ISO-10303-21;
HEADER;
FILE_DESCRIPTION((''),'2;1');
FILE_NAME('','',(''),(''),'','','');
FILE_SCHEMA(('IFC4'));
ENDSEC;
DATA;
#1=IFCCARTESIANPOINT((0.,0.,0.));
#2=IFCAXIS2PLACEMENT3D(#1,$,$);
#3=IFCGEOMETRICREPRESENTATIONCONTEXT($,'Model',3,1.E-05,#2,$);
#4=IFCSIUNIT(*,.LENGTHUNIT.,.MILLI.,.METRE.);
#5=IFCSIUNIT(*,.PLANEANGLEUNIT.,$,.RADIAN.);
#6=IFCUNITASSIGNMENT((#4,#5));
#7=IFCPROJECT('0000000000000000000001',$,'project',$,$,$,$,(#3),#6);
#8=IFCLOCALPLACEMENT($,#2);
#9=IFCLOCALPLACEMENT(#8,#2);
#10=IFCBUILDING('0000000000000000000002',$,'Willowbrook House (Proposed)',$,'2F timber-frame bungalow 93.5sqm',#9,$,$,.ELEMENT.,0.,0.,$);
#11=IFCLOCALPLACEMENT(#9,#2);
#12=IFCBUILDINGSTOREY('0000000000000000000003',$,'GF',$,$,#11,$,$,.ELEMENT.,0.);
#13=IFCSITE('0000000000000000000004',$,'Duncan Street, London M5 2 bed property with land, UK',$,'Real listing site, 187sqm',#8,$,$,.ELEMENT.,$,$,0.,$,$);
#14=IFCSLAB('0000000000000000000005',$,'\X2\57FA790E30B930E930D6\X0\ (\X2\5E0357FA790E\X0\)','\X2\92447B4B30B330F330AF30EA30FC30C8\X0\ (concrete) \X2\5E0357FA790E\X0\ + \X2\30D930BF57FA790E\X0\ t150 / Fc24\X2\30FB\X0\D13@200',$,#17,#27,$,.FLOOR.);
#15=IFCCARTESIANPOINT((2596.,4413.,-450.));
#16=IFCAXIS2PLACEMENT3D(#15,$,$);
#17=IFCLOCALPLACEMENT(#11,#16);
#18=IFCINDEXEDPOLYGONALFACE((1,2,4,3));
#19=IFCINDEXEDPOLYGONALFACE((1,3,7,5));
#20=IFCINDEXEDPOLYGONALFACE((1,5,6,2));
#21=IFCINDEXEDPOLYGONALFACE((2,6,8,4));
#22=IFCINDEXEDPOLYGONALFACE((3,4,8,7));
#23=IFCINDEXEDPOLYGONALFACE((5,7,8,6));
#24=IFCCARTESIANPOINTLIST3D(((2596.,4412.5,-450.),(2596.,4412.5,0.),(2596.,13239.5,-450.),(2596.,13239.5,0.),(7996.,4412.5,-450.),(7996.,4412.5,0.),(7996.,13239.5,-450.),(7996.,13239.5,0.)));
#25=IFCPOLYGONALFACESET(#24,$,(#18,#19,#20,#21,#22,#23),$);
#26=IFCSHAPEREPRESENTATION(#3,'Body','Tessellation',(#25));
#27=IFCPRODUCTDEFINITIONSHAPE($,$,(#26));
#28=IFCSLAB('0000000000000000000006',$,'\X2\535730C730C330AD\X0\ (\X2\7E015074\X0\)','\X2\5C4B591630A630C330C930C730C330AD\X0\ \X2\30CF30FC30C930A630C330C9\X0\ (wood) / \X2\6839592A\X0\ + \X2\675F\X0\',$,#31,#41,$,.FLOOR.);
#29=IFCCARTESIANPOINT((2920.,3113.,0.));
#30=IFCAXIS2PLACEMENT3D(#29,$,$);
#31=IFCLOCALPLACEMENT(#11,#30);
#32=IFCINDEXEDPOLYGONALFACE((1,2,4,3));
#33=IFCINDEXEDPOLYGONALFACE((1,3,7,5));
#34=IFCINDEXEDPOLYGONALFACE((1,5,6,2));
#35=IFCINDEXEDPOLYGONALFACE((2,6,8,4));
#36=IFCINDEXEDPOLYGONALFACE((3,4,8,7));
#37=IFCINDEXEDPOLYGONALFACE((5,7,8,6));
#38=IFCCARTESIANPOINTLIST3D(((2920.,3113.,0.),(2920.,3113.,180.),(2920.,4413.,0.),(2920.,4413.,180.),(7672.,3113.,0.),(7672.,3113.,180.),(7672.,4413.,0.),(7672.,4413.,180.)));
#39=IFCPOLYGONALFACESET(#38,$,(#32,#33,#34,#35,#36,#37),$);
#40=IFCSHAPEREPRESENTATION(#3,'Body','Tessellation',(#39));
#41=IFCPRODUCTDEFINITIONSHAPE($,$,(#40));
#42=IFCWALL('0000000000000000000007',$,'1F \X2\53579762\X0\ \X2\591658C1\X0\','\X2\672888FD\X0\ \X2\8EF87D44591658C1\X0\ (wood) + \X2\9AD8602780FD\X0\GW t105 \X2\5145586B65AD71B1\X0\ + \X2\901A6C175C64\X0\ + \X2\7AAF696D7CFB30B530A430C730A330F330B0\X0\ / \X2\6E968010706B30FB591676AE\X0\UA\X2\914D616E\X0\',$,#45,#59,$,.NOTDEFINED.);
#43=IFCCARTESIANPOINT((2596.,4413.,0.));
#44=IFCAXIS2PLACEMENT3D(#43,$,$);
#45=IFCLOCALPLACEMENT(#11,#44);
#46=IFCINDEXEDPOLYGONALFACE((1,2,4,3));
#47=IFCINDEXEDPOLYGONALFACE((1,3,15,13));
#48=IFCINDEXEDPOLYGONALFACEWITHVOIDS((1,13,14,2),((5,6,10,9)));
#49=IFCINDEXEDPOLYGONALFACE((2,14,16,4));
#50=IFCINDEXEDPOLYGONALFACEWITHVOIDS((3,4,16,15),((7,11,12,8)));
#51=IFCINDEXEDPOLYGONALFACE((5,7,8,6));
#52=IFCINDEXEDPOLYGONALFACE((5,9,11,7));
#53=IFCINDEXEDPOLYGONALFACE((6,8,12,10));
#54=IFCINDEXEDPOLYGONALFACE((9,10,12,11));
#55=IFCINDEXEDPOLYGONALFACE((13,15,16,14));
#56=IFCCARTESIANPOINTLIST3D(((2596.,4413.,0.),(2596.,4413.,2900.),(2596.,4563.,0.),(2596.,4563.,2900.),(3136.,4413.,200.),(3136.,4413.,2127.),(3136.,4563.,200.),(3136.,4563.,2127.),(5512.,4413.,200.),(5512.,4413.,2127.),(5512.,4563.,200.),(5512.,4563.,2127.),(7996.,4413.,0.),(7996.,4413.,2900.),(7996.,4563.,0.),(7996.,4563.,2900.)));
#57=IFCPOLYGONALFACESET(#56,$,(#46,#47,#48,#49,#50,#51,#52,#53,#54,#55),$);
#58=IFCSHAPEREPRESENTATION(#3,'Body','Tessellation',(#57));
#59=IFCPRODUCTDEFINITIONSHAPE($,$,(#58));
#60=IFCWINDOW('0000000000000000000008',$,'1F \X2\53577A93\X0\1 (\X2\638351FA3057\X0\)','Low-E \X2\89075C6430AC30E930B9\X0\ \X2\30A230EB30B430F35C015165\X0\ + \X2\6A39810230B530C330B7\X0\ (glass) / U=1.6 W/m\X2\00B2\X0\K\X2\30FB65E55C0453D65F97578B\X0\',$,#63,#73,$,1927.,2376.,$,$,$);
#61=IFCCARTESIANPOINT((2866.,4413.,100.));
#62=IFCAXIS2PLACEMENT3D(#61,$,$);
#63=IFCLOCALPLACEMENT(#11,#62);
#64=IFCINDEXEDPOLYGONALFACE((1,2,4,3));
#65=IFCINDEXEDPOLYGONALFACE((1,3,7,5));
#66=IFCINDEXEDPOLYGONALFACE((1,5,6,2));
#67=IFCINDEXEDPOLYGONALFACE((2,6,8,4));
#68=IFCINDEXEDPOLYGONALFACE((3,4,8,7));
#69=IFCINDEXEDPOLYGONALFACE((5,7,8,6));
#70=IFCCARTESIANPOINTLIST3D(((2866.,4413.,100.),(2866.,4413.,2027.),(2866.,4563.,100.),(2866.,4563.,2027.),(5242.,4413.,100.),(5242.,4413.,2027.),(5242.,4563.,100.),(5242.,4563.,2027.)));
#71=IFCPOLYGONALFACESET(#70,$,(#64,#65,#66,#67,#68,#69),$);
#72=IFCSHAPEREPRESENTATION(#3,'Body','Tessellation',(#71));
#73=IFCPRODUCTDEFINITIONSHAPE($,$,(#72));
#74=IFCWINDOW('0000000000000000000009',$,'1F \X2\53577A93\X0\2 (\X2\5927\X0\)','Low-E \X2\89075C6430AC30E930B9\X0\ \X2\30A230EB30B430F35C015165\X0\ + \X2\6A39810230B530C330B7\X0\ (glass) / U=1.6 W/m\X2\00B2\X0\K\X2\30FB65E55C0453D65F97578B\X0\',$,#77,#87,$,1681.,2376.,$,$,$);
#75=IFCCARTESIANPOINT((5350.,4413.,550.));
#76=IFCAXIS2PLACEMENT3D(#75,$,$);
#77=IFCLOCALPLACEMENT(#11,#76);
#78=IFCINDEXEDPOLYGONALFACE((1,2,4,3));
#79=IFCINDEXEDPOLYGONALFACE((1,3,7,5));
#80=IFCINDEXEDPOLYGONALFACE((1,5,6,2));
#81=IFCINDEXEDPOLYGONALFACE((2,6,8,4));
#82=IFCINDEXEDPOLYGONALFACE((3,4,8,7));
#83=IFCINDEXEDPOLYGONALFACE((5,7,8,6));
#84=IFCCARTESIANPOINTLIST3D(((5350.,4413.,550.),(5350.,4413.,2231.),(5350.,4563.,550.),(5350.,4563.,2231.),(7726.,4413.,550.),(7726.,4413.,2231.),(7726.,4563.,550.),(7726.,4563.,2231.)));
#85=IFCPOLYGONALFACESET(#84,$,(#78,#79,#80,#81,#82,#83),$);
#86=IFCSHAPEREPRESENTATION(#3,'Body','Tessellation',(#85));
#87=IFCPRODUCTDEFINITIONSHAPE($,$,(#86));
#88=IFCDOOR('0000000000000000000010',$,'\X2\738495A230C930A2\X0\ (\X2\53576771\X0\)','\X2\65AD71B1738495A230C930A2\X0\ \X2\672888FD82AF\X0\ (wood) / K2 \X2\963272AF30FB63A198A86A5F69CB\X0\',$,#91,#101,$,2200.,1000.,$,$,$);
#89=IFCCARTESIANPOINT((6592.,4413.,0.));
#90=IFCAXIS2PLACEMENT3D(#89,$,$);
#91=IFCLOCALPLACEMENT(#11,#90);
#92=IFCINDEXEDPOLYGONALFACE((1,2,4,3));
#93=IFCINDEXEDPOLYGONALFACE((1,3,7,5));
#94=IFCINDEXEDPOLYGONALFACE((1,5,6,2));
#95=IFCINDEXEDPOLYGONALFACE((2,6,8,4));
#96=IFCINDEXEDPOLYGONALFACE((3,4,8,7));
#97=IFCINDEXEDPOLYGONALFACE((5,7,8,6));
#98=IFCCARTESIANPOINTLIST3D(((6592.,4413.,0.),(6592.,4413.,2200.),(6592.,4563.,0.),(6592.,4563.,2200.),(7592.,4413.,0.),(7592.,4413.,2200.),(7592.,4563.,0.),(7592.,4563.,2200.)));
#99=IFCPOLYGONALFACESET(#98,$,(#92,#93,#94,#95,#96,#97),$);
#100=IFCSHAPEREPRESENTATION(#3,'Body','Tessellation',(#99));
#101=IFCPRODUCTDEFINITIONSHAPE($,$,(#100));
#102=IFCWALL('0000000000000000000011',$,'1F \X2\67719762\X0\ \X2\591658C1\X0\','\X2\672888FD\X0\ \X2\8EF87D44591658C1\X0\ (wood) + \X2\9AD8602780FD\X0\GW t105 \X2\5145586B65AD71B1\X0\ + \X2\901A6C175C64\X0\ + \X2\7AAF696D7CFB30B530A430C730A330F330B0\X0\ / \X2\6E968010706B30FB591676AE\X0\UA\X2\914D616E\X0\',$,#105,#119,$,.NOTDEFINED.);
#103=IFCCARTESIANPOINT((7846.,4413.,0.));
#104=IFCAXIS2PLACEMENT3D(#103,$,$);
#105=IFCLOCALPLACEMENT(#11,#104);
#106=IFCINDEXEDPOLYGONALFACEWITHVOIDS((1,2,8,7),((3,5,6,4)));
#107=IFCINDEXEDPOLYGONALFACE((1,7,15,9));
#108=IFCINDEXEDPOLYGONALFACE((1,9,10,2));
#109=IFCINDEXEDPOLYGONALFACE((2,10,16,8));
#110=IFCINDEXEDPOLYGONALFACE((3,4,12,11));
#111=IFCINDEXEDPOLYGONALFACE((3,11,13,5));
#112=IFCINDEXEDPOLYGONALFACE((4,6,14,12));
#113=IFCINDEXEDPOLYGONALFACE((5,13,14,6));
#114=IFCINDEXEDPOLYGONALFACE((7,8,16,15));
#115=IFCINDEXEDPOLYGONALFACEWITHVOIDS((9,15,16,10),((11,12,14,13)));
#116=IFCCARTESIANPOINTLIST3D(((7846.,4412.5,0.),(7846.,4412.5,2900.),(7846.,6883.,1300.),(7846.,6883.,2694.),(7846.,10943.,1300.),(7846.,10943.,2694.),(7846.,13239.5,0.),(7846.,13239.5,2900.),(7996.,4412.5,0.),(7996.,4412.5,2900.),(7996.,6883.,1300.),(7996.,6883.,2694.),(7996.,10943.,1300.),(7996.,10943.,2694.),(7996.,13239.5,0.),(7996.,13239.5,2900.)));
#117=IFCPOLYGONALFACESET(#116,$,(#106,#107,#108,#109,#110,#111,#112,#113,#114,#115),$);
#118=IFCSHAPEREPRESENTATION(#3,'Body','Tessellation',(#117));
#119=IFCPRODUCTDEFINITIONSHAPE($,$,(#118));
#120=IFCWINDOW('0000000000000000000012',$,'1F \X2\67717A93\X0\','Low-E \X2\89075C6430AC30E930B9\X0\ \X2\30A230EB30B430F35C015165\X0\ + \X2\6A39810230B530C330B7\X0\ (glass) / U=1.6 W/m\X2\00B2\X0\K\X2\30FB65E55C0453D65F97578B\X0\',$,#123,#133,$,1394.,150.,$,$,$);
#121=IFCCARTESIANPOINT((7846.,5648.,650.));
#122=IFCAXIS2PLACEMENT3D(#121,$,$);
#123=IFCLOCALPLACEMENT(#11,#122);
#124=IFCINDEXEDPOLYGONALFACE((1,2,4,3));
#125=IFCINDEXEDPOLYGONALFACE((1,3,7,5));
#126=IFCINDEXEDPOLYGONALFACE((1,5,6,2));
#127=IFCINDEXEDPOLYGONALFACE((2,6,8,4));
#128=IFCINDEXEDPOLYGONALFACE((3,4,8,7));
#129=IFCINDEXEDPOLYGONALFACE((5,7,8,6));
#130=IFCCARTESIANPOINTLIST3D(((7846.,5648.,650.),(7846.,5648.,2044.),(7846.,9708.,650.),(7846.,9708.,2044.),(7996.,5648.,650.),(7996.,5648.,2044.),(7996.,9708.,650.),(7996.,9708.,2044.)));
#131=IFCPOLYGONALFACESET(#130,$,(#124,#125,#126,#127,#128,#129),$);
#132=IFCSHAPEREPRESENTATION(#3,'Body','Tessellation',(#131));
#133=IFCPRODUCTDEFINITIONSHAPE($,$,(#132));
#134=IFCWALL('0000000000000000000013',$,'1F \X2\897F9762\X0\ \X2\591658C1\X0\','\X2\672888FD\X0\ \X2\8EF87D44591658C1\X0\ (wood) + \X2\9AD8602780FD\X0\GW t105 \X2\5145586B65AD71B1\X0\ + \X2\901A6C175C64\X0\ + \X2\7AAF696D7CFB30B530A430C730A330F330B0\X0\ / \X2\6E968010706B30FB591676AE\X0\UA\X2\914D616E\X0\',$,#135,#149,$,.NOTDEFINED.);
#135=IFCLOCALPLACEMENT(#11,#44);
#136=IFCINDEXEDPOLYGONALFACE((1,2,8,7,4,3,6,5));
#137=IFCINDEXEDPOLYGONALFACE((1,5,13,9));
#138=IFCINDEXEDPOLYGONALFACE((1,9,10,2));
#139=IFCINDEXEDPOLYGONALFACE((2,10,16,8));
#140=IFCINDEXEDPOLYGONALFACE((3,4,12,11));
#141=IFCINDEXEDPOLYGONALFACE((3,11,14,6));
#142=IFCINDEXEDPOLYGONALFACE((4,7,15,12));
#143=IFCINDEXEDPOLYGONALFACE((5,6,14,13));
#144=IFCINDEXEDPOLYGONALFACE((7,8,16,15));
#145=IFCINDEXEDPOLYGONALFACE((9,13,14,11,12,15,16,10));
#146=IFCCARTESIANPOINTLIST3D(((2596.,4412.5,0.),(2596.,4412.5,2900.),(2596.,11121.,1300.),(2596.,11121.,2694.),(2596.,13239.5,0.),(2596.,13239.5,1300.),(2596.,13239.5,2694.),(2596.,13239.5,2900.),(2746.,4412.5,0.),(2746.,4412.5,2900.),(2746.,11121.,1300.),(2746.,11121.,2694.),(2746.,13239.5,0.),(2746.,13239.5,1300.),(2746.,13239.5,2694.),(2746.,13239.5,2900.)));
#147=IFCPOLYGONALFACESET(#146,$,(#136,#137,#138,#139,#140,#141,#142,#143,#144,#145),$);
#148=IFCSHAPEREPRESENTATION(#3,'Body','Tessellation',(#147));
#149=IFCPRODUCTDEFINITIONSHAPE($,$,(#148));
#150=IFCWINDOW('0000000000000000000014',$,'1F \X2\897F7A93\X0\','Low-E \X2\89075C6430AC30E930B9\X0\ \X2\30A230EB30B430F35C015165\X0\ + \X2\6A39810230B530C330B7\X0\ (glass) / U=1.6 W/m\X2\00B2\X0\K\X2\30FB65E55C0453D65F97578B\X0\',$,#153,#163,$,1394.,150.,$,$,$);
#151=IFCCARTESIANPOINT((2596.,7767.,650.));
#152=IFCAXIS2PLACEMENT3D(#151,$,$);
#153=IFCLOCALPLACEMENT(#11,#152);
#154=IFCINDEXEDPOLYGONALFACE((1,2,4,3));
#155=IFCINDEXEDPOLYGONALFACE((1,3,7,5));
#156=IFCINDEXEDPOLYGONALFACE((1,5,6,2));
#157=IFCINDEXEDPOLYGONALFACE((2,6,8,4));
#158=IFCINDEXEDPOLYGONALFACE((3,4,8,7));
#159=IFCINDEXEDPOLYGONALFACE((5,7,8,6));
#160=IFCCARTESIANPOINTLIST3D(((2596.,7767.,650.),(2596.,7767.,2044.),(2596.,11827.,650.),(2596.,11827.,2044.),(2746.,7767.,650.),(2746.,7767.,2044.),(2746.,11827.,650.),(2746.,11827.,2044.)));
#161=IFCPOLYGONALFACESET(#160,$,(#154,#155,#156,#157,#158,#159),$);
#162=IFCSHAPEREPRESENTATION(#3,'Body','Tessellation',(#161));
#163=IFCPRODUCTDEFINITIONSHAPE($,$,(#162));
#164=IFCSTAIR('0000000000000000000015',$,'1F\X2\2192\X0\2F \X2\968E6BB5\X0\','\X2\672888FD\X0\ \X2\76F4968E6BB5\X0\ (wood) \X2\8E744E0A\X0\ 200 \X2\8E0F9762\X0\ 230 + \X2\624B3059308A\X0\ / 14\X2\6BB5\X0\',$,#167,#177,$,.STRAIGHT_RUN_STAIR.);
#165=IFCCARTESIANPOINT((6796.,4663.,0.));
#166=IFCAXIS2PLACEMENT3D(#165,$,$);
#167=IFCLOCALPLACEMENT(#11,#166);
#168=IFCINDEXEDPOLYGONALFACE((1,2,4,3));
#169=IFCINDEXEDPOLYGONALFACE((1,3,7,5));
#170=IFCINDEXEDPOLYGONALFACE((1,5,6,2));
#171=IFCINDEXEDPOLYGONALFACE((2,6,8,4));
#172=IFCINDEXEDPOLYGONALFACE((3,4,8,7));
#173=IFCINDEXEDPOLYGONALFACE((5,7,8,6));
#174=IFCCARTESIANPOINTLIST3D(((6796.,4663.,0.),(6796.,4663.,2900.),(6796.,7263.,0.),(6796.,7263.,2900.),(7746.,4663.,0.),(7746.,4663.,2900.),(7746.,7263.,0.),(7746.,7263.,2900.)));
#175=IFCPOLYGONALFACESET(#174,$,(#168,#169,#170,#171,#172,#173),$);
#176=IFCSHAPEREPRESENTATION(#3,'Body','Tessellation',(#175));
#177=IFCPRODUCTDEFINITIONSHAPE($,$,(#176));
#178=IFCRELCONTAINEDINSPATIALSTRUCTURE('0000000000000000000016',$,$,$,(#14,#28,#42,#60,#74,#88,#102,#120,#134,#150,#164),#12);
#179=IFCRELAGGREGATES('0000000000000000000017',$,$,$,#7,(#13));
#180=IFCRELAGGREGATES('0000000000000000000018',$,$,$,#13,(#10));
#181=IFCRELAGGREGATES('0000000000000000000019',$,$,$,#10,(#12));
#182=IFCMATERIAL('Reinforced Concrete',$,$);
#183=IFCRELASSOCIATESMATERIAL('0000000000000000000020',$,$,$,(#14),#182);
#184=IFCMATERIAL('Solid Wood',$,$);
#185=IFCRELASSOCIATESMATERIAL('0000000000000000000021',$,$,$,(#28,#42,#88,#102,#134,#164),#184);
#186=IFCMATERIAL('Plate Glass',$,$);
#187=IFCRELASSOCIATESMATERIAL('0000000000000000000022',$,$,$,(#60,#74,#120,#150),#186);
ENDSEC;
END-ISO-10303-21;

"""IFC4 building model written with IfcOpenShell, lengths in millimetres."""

from ifc_helpers import new_model, si_unit, frame, frame_2d, origin, place, context, project, spatial, rectangle, extrude, material, element, fill, save


model = new_model("IFC4")

# Units and contexts
model_context = context("Model", 3, precision=1e-05, world=origin())
ifc_project = project(units=[si_unit("LENGTHUNIT", "METRE", prefix="MILLI"), si_unit("PLANEANGLEUNIT", "RADIAN")], contexts=[model_context])

# Site, building, storey
site_placement = place(None, origin())
site = spatial("IfcSite", under=ifc_project, at=site_placement, Name="Duncan Street, London M5 2 bed property with land, UK", ObjectType="Real listing site, 187sqm", CompositionType="ELEMENT", RefElevation=0.0)
building_placement = place(site_placement, origin())
building = spatial("IfcBuilding", under=site, at=building_placement, Name="Willowbrook House (Proposed)", ObjectType="2F timber-frame bungalow 93.5sqm", CompositionType="ELEMENT", ElevationOfRefHeight=0.0, ElevationOfTerrain=0.0)
storey_placement = place(building_placement, origin())
storey = spatial("IfcBuildingStorey", under=building, at=storey_placement, Name="GF", CompositionType="ELEMENT", Elevation=0.0)

# Slabs
ifc_material_1 = material(Name="Reinforced Concrete")
slab_1_placement = place(storey_placement, frame((2596.0, 4413.0, -450.0)))
element("IfcSlab", 1, at=slab_1_placement, inside=storey, material=ifc_material_1, Name="基礎スラブ (布基礎)", Description="鉄筋コンクリート (concrete) 布基礎 + ベタ基礎 t150 / Fc24・D13@200", PredefinedType="FLOOR", context=model_context, shape_type="SweptSolid", body=[
    extrude(rectangle(XDim=5400.0, YDim=8827.0, at=frame_2d((2700.0, 4413.0))), frame((2596.0, 4413.0, -450.0)), (0.0, 0.0, 1.0), 450.0),
])
ifc_material_2 = material(Name="Solid Wood")
slab_2_placement = place(storey_placement, frame((2920.0, 3113.0, 0.0)))
element("IfcSlab", 2, at=slab_2_placement, inside=storey, material=ifc_material_2, Name="南デッキ (縁側)", Description="屋外ウッドデッキ ハードウッド (wood) / 根太 + 束", PredefinedType="FLOOR", context=model_context, shape_type="SweptSolid", body=[
    extrude(rectangle(XDim=4752.0, YDim=1300.0, at=frame_2d((2376.0, 650.0))), frame((2920.0, 3113.0, 0.0)), (0.0, 0.0, 1.0), 180.0),
])

# Wall, openings, windows, door
wall_1_placement = place(storey_placement, frame((2596.0, 4413.0, 0.0)))
wall_1 = element("IfcWall", 3, at=wall_1_placement, inside=storey, material=ifc_material_2, Name="1F 南面 外壁", Description="木製 軸組外壁 (wood) + 高性能GW t105 充填断熱 + 通気層 + 窯業系サイディング / 準耐火・外皮UA配慮", PredefinedType="NOTDEFINED", context=model_context, shape_type="SweptSolid", body=[
    extrude(rectangle(XDim=5400.0, YDim=150.0, at=frame_2d((2700.0, 75.0))), frame((2596.0, 4413.0, 0.0)), (0.0, 0.0, 1.0), 2900.0),
])
opening_1_placement = place(storey_placement, frame((2866.0, 4413.0, 100.0)))
opening_1 = element("IfcOpeningElement", 4, at=opening_1_placement, cuts=wall_1, PredefinedType="NOTDEFINED", context=model_context, shape_type="SweptSolid", body=[
    extrude(rectangle(XDim=2376.0, YDim=150.0, at=frame_2d((1188.0, 75.0))), frame((2866.0, 4413.0, 100.0)), (0.0, 0.0, 1.0), 1927.0),
])
opening_2_placement = place(storey_placement, frame((5350.0, 4413.0, 550.0)))
opening_2 = element("IfcOpeningElement", 5, at=opening_2_placement, cuts=wall_1, PredefinedType="NOTDEFINED", context=model_context, shape_type="SweptSolid", body=[
    extrude(rectangle(XDim=2376.0, YDim=150.0, at=frame_2d((1188.0, 75.0))), frame((5350.0, 4413.0, 550.0)), (0.0, 0.0, 1.0), 1681.0),
])
opening_3_placement = place(storey_placement, frame((6592.0, 4413.0, 0.0)))
opening_3 = element("IfcOpeningElement", 6, at=opening_3_placement, cuts=wall_1, PredefinedType="NOTDEFINED", context=model_context, shape_type="SweptSolid", body=[
    extrude(rectangle(XDim=1000.0, YDim=150.0, at=frame_2d((500.0, 75.0))), frame((6592.0, 4413.0, 0.0)), (0.0, 0.0, 1.0), 2200.0),
])
ifc_material_3 = material(Name="Plate Glass")
window_1_placement = place(storey_placement, frame((2866.0, 4413.0, 100.0)))
window_1 = element("IfcWindow", 7, at=window_1_placement, inside=storey, material=ifc_material_3, Name="1F 南窓1 (掃出し)", Description="Low-E 複層ガラス アルゴン封入 + 樹脂サッシ (glass) / U=1.6 W/m²K・日射取得型", OverallHeight=1927.0, OverallWidth=2376.0, context=model_context, shape_type="SweptSolid", body=[
    extrude(rectangle(XDim=2376.0, YDim=150.0, at=frame_2d((1188.0, 75.0))), frame((2866.0, 4413.0, 100.0)), (0.0, 0.0, 1.0), 1927.0),
])
fill(opening_1, window_1)
window_2_placement = place(storey_placement, frame((5350.0, 4413.0, 550.0)))
window_2 = element("IfcWindow", 8, at=window_2_placement, inside=storey, material=ifc_material_3, Name="1F 南窓2 (大)", Description="Low-E 複層ガラス アルゴン封入 + 樹脂サッシ (glass) / U=1.6 W/m²K・日射取得型", OverallHeight=1681.0, OverallWidth=2376.0, context=model_context, shape_type="SweptSolid", body=[
    extrude(rectangle(XDim=2376.0, YDim=150.0, at=frame_2d((1188.0, 75.0))), frame((5350.0, 4413.0, 550.0)), (0.0, 0.0, 1.0), 1681.0),
])
fill(opening_2, window_2)
door_placement = place(storey_placement, frame((6592.0, 4413.0, 0.0)))
door = element("IfcDoor", 9, at=door_placement, inside=storey, material=ifc_material_2, Name="玄関ドア (南東)", Description="断熱玄関ドア 木製芯 (wood) / K2 防犯・採風機構", OverallHeight=2200.0, OverallWidth=1000.0, context=model_context, shape_type="SweptSolid", body=[
    extrude(rectangle(XDim=1000.0, YDim=150.0, at=frame_2d((500.0, 75.0))), frame((6592.0, 4413.0, 0.0)), (0.0, 0.0, 1.0), 2200.0),
])
fill(opening_3, door)

# Walls, openings, windows
wall_2_placement = place(storey_placement, frame((7846.0, 4413.0, 0.0)))
wall_2 = element("IfcWall", 10, at=wall_2_placement, inside=storey, material=ifc_material_2, Name="1F 東面 外壁", Description="木製 軸組外壁 (wood) + 高性能GW t105 充填断熱 + 通気層 + 窯業系サイディング / 準耐火・外皮UA配慮", PredefinedType="NOTDEFINED", context=model_context, shape_type="SweptSolid", body=[
    extrude(rectangle(XDim=150.0, YDim=8827.0, at=frame_2d((75.0, 4413.0))), frame((7846.0, 4413.0, 0.0)), (0.0, 0.0, 1.0), 2900.0),
])
opening_4_placement = place(storey_placement, frame((7846.0, 5648.0, 650.0)))
opening_4 = element("IfcOpeningElement", 11, at=opening_4_placement, cuts=wall_2, PredefinedType="NOTDEFINED", context=model_context, shape_type="SweptSolid", body=[
    extrude(rectangle(XDim=150.0, YDim=4060.0, at=frame_2d((75.0, 2030.0))), frame((7846.0, 5648.0, 650.0)), (0.0, 0.0, 1.0), 1394.0),
])
window_3_placement = place(storey_placement, frame((7846.0, 5648.0, 650.0)))
window_3 = element("IfcWindow", 12, at=window_3_placement, inside=storey, material=ifc_material_3, Name="1F 東窓", Description="Low-E 複層ガラス アルゴン封入 + 樹脂サッシ (glass) / U=1.6 W/m²K・日射取得型", OverallHeight=1394.0, OverallWidth=150.0, context=model_context, shape_type="SweptSolid", body=[
    extrude(rectangle(XDim=150.0, YDim=4060.0, at=frame_2d((75.0, 2030.0))), frame((7846.0, 5648.0, 650.0)), (0.0, 0.0, 1.0), 1394.0),
])
fill(opening_4, window_3)
wall_3_placement = place(storey_placement, frame((2596.0, 4413.0, 0.0)))
wall_3 = element("IfcWall", 13, at=wall_3_placement, inside=storey, material=ifc_material_2, Name="1F 西面 外壁", Description="木製 軸組外壁 (wood) + 高性能GW t105 充填断熱 + 通気層 + 窯業系サイディング / 準耐火・外皮UA配慮", PredefinedType="NOTDEFINED", context=model_context, shape_type="SweptSolid", body=[
    extrude(rectangle(XDim=150.0, YDim=8827.0, at=frame_2d((75.0, 4413.0))), frame((2596.0, 4413.0, 0.0)), (0.0, 0.0, 1.0), 2900.0),
])
opening_5_placement = place(storey_placement, frame((2596.0, 7767.0, 650.0)))
opening_5 = element("IfcOpeningElement", 14, at=opening_5_placement, cuts=wall_3, PredefinedType="NOTDEFINED", context=model_context, shape_type="SweptSolid", body=[
    extrude(rectangle(XDim=150.0, YDim=4060.0, at=frame_2d((75.0, 2030.0))), frame((2596.0, 7767.0, 650.0)), (0.0, 0.0, 1.0), 1394.0),
])
window_4_placement = place(storey_placement, frame((2596.0, 7767.0, 650.0)))
window_4 = element("IfcWindow", 15, at=window_4_placement, inside=storey, material=ifc_material_3, Name="1F 西窓", Description="Low-E 複層ガラス アルゴン封入 + 樹脂サッシ (glass) / U=1.6 W/m²K・日射取得型", OverallHeight=1394.0, OverallWidth=150.0, context=model_context, shape_type="SweptSolid", body=[
    extrude(rectangle(XDim=150.0, YDim=4060.0, at=frame_2d((75.0, 2030.0))), frame((2596.0, 7767.0, 650.0)), (0.0, 0.0, 1.0), 1394.0),
])
fill(opening_5, window_4)

# Stair
stair_placement = place(storey_placement, frame((6796.0, 4663.0, 0.0)))
element("IfcStair", 16, at=stair_placement, inside=storey, material=ifc_material_2, Name="1F→2F 階段", Description="木製 直階段 (wood) 蹴上 200 踏面 230 + 手すり / 14段", PredefinedType="STRAIGHT_RUN_STAIR", context=model_context, shape_type="SweptSolid", body=[
    extrude(rectangle(XDim=950.0, YDim=2600.0, at=frame_2d((475.0, 1300.0))), frame((6796.0, 4663.0, 0.0)), (0.0, 0.0, 1.0), 2900.0),
])

save(model, "model.ifc")
